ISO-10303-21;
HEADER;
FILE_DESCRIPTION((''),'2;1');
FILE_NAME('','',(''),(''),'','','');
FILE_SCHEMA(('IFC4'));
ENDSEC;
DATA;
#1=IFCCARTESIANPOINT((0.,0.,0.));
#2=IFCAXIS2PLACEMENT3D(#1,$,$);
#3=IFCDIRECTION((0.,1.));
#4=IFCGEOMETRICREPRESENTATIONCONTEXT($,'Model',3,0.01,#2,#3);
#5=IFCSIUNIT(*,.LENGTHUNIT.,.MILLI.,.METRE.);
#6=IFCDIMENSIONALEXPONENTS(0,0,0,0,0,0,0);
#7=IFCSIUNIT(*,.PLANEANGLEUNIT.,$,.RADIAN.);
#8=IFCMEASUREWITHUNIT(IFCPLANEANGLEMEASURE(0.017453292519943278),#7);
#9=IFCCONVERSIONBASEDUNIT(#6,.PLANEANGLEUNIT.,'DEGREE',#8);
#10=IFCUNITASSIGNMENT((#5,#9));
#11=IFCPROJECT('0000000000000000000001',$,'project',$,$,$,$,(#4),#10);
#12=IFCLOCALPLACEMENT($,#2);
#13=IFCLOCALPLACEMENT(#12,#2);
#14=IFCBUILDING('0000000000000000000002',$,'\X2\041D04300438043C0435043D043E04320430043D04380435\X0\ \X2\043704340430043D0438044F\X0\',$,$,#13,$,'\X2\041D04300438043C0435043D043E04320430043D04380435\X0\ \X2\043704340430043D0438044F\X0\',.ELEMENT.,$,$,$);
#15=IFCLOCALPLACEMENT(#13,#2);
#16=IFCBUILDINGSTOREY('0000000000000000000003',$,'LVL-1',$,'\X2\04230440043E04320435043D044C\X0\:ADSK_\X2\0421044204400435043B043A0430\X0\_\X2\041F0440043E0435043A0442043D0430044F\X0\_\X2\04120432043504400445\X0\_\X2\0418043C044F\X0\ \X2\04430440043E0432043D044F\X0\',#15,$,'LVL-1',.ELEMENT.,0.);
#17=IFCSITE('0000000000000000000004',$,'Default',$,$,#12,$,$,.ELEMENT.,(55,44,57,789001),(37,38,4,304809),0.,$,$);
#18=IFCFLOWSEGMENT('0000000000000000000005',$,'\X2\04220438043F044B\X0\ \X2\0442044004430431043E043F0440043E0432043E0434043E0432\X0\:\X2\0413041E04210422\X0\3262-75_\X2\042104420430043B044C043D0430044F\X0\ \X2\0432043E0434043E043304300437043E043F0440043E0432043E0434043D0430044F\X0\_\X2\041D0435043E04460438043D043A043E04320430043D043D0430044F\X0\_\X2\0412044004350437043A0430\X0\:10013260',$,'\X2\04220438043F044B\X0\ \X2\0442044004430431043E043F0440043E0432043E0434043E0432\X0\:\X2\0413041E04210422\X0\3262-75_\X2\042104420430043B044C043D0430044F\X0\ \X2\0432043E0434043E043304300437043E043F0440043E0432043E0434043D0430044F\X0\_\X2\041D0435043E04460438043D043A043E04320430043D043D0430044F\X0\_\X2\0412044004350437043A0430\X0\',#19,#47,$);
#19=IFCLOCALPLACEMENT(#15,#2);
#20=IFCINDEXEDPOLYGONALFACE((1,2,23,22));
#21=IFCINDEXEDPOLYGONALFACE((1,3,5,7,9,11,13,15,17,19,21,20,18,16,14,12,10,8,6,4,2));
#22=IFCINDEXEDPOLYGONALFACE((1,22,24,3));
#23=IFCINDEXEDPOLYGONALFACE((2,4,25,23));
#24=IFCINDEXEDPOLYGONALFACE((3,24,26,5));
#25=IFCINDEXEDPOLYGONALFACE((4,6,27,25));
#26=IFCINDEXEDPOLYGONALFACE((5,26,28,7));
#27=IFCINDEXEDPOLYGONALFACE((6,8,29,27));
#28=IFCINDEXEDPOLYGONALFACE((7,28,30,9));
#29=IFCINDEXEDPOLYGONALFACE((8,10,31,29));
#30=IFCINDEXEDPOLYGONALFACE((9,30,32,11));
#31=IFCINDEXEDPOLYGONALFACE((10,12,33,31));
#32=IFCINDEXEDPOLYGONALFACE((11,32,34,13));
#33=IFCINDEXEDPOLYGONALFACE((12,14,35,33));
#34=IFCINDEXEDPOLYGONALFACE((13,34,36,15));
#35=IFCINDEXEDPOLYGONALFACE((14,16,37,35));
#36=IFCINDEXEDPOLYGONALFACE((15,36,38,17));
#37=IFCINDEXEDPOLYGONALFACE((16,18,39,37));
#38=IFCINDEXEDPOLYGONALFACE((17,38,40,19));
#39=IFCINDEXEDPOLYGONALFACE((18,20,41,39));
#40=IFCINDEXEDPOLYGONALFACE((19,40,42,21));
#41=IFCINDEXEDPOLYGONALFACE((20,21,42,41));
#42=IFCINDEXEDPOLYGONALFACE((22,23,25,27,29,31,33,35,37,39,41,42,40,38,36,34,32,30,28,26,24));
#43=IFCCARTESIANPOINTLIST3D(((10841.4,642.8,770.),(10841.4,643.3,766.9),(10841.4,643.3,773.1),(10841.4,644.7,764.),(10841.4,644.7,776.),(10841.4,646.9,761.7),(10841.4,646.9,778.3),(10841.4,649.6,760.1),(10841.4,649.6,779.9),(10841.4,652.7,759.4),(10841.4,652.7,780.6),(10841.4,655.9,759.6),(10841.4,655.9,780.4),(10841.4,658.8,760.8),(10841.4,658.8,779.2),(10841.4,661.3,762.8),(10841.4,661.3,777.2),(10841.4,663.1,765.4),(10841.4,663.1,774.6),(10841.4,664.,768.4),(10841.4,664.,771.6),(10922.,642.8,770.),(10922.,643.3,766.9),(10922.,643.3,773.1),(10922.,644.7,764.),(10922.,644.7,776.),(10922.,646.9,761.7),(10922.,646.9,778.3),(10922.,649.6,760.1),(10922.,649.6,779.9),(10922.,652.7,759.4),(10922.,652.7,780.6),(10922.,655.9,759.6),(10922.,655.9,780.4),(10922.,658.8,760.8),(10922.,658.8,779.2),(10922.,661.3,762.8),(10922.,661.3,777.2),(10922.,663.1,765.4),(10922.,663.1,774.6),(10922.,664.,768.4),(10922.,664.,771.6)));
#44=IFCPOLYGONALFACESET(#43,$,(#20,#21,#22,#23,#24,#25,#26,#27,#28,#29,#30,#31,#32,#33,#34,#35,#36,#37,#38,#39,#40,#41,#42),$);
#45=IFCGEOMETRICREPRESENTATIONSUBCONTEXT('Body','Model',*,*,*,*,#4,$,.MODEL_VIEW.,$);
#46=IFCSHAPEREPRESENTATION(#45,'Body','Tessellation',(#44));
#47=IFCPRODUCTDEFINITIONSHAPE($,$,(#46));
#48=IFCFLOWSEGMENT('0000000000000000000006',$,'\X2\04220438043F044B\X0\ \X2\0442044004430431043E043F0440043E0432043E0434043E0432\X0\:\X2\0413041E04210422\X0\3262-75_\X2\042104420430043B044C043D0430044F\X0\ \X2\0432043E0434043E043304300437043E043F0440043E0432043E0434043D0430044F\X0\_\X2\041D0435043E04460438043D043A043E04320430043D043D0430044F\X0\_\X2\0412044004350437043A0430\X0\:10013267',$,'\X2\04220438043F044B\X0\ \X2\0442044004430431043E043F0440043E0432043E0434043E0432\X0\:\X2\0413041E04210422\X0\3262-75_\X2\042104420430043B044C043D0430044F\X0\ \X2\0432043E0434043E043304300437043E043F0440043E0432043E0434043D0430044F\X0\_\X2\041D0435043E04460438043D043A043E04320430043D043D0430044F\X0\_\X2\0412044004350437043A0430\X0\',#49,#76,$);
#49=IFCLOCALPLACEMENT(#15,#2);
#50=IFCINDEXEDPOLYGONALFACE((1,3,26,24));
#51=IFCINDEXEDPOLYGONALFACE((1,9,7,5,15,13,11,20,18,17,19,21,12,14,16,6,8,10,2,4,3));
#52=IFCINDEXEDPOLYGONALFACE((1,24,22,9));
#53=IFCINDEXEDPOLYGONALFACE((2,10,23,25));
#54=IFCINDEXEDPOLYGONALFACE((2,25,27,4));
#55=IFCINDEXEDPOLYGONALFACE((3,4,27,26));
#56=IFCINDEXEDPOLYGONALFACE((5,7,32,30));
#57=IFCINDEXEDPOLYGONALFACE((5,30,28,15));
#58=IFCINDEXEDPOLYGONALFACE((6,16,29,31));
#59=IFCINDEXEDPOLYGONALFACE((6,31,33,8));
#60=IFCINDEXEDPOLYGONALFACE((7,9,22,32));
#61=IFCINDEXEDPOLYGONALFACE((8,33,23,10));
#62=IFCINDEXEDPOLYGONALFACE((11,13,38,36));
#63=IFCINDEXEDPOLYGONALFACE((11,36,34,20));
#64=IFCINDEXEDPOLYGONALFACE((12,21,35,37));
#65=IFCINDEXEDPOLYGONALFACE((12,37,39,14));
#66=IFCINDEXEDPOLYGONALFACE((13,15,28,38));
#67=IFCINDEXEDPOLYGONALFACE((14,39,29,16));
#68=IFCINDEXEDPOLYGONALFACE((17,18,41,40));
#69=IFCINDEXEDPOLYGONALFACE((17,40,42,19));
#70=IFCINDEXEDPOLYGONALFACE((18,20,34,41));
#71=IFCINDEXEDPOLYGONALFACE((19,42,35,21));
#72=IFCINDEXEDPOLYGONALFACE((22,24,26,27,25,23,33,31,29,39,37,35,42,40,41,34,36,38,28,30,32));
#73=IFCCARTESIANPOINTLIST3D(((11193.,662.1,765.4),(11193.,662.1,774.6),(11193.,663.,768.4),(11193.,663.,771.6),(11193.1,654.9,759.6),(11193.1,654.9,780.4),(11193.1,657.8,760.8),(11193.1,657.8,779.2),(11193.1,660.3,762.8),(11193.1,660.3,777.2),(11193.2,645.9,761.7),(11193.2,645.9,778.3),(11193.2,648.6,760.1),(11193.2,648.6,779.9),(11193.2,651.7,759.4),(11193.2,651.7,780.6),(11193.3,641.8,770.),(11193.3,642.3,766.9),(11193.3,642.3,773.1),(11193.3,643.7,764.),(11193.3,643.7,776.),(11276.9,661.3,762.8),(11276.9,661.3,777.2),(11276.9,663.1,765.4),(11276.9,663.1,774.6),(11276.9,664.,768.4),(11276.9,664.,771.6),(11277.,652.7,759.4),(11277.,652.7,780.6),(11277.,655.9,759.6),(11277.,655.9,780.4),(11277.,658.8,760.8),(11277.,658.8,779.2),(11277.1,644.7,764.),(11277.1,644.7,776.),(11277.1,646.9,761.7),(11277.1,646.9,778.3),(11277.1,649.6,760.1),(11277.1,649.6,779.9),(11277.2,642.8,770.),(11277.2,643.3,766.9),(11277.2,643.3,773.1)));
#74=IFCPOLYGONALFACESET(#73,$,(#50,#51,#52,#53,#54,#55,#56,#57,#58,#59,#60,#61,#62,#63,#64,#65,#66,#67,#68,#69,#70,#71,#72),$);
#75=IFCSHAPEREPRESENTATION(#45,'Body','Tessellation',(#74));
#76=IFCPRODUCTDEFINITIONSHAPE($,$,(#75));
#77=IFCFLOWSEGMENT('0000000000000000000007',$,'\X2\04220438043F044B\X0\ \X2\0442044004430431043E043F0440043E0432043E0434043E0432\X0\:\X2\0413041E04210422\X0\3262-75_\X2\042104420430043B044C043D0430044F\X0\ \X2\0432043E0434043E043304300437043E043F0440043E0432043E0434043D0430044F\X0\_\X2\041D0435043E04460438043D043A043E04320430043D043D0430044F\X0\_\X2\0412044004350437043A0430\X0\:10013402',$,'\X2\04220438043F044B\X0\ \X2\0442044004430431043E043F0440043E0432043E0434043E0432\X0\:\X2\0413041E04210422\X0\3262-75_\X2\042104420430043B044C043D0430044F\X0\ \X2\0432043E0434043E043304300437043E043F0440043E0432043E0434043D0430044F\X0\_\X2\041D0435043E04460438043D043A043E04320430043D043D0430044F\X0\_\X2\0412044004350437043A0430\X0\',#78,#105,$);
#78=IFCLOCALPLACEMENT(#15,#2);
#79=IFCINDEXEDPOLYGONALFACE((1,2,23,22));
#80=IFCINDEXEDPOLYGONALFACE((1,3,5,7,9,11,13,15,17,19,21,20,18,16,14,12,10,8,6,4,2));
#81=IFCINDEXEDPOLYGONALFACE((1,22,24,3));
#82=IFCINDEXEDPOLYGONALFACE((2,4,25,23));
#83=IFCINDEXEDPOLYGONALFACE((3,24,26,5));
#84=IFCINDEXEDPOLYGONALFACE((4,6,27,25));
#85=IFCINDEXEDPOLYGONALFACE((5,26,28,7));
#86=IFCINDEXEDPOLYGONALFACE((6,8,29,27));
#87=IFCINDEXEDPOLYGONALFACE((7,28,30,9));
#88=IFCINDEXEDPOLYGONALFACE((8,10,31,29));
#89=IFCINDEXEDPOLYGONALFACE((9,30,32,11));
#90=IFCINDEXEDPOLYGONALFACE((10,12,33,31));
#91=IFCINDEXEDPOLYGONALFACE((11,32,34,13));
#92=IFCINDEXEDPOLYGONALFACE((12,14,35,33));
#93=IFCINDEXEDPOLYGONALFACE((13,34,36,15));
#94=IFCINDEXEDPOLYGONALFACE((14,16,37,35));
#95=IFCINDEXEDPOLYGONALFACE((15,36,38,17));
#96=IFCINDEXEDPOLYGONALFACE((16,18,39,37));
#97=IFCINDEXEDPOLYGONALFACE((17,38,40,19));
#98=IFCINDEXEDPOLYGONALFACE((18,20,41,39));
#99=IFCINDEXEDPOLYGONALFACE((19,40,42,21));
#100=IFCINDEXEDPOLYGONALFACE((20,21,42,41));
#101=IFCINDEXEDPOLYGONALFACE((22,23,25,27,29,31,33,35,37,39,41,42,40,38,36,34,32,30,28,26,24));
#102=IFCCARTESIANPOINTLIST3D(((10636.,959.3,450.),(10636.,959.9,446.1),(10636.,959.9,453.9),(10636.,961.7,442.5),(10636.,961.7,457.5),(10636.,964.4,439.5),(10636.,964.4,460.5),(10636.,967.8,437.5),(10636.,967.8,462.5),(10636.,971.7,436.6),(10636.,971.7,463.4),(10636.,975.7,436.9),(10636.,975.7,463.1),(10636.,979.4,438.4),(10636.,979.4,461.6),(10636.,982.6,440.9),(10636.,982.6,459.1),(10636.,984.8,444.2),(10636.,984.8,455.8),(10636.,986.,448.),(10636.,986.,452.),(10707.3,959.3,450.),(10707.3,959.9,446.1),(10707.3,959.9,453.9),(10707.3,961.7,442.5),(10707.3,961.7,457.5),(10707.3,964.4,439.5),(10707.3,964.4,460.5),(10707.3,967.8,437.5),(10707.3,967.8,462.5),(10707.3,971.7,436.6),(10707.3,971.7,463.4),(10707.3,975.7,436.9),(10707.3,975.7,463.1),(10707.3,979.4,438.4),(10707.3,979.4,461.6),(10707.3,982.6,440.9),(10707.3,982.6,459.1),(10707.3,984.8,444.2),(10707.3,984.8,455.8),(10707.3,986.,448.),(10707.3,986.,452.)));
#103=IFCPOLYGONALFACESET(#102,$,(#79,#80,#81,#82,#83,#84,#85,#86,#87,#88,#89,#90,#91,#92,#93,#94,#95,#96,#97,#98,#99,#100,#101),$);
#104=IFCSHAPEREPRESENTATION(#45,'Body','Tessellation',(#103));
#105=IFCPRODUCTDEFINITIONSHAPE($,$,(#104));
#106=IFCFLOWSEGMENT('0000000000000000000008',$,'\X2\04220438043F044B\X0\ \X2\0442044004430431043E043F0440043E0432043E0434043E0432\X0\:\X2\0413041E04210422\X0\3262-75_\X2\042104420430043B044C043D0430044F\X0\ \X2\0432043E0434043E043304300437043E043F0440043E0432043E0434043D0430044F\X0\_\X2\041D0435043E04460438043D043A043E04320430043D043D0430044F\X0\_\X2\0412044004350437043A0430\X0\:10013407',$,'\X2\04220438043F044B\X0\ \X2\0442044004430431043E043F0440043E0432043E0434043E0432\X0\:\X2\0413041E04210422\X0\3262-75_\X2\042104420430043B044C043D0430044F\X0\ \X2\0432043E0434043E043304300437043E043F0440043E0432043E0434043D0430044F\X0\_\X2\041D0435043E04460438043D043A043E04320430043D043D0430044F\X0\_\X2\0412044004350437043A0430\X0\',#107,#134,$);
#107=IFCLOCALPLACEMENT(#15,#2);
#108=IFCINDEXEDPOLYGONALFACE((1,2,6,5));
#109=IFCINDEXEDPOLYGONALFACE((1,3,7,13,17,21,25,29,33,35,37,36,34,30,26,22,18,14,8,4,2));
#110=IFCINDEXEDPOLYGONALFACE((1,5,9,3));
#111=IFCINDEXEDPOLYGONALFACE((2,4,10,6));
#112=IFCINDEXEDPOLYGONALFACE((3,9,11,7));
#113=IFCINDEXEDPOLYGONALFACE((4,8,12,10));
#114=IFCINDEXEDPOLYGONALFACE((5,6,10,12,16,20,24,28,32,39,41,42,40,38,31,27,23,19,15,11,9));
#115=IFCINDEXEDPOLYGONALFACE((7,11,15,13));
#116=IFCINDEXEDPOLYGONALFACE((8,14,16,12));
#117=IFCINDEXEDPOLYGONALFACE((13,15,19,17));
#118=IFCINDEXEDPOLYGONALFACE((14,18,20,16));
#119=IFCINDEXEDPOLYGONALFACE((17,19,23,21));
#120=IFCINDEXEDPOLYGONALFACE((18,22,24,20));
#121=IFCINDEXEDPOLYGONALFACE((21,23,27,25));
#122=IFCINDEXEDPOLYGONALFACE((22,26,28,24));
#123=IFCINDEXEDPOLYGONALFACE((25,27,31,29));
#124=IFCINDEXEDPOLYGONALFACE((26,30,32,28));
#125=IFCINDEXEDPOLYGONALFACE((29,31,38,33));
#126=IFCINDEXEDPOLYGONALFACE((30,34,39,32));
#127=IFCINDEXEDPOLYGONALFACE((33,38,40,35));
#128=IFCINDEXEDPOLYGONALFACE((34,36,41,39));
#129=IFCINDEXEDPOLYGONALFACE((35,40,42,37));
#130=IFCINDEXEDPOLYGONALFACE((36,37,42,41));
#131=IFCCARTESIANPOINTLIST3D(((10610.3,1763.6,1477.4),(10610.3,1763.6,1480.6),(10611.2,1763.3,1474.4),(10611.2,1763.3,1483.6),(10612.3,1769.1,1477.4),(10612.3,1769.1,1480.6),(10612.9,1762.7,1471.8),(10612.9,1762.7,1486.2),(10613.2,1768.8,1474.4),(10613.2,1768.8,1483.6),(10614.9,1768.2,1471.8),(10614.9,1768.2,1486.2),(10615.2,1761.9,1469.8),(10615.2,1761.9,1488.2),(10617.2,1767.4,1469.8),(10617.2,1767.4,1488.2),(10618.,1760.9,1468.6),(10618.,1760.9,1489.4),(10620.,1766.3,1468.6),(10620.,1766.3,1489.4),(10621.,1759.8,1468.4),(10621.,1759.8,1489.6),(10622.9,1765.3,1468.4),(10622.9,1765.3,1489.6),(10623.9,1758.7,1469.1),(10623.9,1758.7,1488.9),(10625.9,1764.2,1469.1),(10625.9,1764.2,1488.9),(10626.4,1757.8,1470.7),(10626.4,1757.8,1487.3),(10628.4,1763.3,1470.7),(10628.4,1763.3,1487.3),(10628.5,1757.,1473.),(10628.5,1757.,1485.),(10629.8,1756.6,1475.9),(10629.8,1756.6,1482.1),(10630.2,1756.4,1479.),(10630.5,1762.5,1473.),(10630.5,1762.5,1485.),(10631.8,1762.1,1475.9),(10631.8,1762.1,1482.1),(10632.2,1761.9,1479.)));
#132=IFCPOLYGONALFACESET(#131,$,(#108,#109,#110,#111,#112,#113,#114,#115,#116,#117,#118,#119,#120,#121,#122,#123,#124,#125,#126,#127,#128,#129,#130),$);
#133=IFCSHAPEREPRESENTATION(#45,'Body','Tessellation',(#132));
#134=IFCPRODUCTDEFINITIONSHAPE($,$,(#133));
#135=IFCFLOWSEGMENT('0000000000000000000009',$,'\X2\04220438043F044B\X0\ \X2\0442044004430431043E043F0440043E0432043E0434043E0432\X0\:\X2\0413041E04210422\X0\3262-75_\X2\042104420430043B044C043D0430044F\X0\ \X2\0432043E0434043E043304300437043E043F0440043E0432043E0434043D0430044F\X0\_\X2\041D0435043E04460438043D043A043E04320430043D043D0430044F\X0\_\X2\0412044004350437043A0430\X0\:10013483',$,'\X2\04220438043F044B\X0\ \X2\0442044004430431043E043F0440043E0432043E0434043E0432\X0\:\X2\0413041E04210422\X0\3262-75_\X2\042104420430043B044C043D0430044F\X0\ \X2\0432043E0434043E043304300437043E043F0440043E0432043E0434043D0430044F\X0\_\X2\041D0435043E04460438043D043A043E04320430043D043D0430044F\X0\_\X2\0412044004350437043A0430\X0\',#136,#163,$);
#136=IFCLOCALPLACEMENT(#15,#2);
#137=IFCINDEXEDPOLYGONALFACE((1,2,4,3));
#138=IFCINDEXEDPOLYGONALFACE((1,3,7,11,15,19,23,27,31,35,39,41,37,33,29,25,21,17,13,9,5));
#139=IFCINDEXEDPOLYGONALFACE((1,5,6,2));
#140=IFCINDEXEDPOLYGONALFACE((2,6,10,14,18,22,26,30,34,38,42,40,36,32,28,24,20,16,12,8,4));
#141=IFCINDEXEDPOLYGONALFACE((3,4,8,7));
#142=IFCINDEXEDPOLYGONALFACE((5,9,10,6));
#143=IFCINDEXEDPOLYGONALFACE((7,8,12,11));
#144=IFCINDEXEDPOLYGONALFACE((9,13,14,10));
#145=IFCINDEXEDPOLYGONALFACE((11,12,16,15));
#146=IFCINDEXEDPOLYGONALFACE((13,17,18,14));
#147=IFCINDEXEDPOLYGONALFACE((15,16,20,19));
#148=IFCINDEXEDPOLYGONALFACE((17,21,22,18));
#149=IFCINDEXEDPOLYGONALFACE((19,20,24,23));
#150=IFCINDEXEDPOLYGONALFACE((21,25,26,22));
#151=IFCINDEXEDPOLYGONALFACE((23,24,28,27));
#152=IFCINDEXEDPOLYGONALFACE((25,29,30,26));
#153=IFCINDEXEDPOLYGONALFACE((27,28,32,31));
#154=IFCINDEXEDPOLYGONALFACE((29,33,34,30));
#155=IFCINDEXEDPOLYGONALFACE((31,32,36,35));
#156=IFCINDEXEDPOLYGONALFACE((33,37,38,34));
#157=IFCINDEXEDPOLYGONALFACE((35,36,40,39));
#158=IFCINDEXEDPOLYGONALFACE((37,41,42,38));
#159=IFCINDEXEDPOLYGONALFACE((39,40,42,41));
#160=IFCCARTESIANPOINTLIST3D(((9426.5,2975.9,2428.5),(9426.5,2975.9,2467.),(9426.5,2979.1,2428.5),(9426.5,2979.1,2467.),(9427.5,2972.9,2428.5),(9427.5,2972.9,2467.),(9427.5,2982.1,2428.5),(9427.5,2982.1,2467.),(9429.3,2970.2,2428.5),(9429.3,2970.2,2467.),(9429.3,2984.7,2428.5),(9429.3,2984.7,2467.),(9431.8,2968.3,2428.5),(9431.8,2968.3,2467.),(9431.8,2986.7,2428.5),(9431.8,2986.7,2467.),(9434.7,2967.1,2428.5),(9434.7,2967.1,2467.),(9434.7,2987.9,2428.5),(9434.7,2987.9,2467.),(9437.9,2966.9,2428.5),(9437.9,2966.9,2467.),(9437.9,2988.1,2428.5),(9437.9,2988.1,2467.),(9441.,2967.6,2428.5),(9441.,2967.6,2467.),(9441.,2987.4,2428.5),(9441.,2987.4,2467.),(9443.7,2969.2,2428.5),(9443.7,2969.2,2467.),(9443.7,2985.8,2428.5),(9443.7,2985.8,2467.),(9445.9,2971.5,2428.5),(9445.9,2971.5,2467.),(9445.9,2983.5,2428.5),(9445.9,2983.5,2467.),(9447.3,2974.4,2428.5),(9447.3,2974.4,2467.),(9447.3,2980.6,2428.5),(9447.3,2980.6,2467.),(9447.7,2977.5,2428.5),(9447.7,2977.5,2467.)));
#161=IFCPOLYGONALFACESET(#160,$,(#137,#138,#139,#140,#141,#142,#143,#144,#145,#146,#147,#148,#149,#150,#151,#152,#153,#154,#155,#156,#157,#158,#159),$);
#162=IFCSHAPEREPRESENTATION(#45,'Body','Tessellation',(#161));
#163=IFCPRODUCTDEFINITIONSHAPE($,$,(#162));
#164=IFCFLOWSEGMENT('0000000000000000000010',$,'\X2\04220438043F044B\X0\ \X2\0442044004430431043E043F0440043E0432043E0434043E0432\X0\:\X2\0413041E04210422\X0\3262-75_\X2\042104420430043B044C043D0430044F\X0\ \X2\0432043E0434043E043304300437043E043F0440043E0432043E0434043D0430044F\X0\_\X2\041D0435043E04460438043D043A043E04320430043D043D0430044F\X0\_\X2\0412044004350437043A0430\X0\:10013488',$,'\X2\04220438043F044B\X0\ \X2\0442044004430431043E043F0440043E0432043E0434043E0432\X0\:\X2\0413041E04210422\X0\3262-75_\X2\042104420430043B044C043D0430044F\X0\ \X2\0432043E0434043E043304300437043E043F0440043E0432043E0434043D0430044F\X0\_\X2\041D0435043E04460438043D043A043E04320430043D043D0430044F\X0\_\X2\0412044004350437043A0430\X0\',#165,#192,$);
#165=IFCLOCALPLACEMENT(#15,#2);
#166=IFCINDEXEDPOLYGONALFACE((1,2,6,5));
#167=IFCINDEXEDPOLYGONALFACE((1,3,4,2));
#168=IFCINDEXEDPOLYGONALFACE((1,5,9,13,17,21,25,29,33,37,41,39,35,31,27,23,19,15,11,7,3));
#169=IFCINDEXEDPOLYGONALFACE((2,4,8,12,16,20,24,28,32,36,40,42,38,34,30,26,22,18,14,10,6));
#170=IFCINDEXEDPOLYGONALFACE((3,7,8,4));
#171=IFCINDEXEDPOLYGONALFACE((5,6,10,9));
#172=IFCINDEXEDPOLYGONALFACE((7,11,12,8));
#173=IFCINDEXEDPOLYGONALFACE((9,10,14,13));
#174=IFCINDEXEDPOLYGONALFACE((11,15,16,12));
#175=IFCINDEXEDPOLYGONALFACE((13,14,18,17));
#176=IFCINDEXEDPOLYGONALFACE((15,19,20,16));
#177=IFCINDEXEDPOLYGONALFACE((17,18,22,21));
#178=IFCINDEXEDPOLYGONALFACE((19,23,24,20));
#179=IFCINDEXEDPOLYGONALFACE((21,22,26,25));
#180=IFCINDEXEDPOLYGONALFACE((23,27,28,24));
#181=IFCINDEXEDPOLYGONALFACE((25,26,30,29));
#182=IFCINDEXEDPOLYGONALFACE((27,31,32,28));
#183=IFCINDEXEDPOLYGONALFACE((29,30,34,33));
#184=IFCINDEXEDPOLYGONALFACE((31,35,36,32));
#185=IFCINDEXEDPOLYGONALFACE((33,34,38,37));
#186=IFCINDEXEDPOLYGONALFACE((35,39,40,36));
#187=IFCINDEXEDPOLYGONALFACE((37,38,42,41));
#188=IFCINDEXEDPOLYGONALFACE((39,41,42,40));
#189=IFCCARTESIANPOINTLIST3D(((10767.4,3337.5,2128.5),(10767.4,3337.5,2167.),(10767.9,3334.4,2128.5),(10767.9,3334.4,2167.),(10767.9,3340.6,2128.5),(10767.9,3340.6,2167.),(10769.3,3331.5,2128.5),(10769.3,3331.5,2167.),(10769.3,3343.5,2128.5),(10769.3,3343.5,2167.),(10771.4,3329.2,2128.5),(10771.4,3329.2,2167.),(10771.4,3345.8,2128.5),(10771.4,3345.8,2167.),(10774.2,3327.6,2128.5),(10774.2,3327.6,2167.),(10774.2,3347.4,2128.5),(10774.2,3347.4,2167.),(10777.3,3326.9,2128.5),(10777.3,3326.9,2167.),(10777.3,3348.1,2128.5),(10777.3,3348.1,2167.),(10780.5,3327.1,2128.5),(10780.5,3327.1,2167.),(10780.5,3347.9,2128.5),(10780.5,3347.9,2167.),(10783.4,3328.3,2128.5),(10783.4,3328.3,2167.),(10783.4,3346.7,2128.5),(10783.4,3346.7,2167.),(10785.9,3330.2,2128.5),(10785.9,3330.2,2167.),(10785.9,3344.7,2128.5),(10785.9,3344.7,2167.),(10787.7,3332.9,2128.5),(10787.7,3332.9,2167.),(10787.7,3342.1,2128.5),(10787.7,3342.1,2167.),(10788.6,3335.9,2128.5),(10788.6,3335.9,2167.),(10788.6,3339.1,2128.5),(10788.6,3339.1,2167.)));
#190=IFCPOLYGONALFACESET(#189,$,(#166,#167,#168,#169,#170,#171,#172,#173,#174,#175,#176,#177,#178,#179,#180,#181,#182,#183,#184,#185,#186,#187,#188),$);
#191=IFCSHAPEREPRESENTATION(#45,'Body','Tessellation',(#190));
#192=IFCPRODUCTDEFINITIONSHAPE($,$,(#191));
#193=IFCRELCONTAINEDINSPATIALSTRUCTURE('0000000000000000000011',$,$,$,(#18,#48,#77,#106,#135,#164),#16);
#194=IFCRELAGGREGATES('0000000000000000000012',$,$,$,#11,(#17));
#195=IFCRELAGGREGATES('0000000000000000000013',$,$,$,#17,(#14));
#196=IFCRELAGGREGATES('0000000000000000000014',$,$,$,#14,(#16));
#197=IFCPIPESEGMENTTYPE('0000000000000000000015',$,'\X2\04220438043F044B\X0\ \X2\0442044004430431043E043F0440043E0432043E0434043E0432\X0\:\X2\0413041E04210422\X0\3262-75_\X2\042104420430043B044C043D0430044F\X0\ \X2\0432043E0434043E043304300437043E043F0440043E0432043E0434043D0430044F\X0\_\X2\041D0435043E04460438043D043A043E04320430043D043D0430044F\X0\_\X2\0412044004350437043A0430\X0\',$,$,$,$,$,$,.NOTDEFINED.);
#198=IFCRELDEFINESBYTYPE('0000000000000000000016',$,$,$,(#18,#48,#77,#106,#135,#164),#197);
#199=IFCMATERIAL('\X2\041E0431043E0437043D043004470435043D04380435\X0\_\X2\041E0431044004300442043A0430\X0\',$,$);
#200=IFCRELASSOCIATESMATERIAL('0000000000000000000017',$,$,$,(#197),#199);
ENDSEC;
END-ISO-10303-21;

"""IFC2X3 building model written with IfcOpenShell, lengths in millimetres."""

from ifc_helpers import new_model, entity, si_unit, converted_unit, direction, frame, frame_2d, origin, origin_2d_with_axis, place, context, subcontext, project, spatial, circle, extrude, material, type_object, element, save


model = new_model("IFC2X3")

# Units and contexts
model_context = context("Model", 3, precision=0.01, world=origin(), true_north=direction((0.0, 1.0)))
body_context = subcontext(model_context, "Body", "Model", "MODEL_VIEW")
ifc_project = project(units=[si_unit("LENGTHUNIT", "METRE", prefix="MILLI"), converted_unit("PLANEANGLEUNIT", "DEGREE", entity("IfcPlaneAngleMeasure", 0.017453292519943278), si_unit("PLANEANGLEUNIT", "RADIAN"), dimensions=[0, 0, 0, 0, 0, 0, 0])], contexts=[model_context])

# Site, building, storey
site_placement = place(None, origin())
site = spatial("IfcSite", under=ifc_project, at=site_placement, Name="Default", CompositionType="ELEMENT", RefLatitude=(55, 44, 57, 789001), RefLongitude=(37, 38, 4, 304809), RefElevation=0.0)
building_placement = place(site_placement, origin())
building = spatial("IfcBuilding", under=site, at=building_placement, Name="Наименование здания", LongName="Наименование здания", CompositionType="ELEMENT")
storey_placement = place(building_placement, origin())
storey = spatial("IfcBuildingStorey", under=building, at=storey_placement, Name="LVL-1", ObjectType="Уровень:ADSK_Стрелка_Проектная_Вверх_Имя уровня", LongName="LVL-1", CompositionType="ELEMENT", Elevation=0.0)

# Flow segments
ifc_material_1 = material(Name="Обозначение_Обратка")
pipe_segment_type_1 = type_object("IfcPipeSegmentType", Name="Типы трубопроводов:ГОСТ3262-75_Стальная водогазопроводная_Неоцинкованная_Врезка", PredefinedType="NOTDEFINED", material=ifc_material_1)
flow_segment_1_placement = place(storey_placement, origin())
element("IfcFlowSegment", 1, at=flow_segment_1_placement, inside=storey, type_object=pipe_segment_type_1, Name="Типы трубопроводов:ГОСТ3262-75_Стальная водогазопроводная_Неоцинкованная_Врезка:10013260", ObjectType="Типы трубопроводов:ГОСТ3262-75_Стальная водогазопроводная_Неоцинкованная_Врезка", context=body_context, shape_type="SweptSolid", body=[
    extrude(circle(Radius=10.7, at=origin_2d_with_axis()), frame((10841.4, 653.5, 770.0), z_axis=(1.0, 0.0, 0.0), x_axis=(0.0, -1.0, 0.0)), (0.0, 0.0, 1.0), 80.7),
])
flow_segment_2_placement = place(storey_placement, origin())
element("IfcFlowSegment", 2, at=flow_segment_2_placement, inside=storey, type_object=pipe_segment_type_1, Name="Типы трубопроводов:ГОСТ3262-75_Стальная водогазопроводная_Неоцинкованная_Врезка:10013267", ObjectType="Типы трубопроводов:ГОСТ3262-75_Стальная водогазопроводная_Неоцинкованная_Врезка", context=body_context, shape_type="SweptSolid", body=[
    extrude(circle(Radius=10.7, at=frame_2d((0.0, 0.0), x_axis=(1.0, 0.0))), frame((11193.2, 652.5, 770.0), z_axis=(0.999929, 0.011923, 0.0), x_axis=(0.011923, -0.999929, 0.0)), (0.0, 0.0, 1.0), 83.9),
])
flow_segment_3_placement = place(storey_placement, origin())
element("IfcFlowSegment", 3, at=flow_segment_3_placement, inside=storey, type_object=pipe_segment_type_1, Name="Типы трубопроводов:ГОСТ3262-75_Стальная водогазопроводная_Неоцинкованная_Врезка:10013402", ObjectType="Типы трубопроводов:ГОСТ3262-75_Стальная водогазопроводная_Неоцинкованная_Врезка", context=body_context, shape_type="SweptSolid", body=[
    extrude(circle(Radius=13.4, at=frame_2d((0.0, 0.0), x_axis=(1.0, 0.0))), frame((10636.0, 972.7, 450.0), z_axis=(1.0, 0.0, 0.0), x_axis=(0.0, -1.0, 0.0)), (0.0, 0.0, 1.0), 71.3),
])
flow_segment_4_placement = place(storey_placement, origin())
element("IfcFlowSegment", 4, at=flow_segment_4_placement, inside=storey, type_object=pipe_segment_type_1, Name="Типы трубопроводов:ГОСТ3262-75_Стальная водогазопроводная_Неоцинкованная_Врезка:10013407", ObjectType="Типы трубопроводов:ГОСТ3262-75_Стальная водогазопроводная_Неоцинкованная_Врезка", context=body_context, shape_type="SweptSolid", body=[
    extrude(circle(Radius=10.7, at=frame_2d((0.0, 0.0), x_axis=(1.0, 0.0))), frame((10620.2, 1760.0, 1479.0), z_axis=(0.34202, 0.939693, 0.0), x_axis=(0.939693, -0.34202, 0.0)), (0.0, 0.0, 1.0), 5.8),
])
flow_segment_5_placement = place(storey_placement, origin())
element("IfcFlowSegment", 5, at=flow_segment_5_placement, inside=storey, type_object=pipe_segment_type_1, Name="Типы трубопроводов:ГОСТ3262-75_Стальная водогазопроводная_Неоцинкованная_Врезка:10013483", ObjectType="Типы трубопроводов:ГОСТ3262-75_Стальная водогазопроводная_Неоцинкованная_Врезка", context=body_context, shape_type="SweptSolid", body=[
    extrude(circle(Radius=10.7, at=origin_2d_with_axis()), frame((9437.1, 2977.5, 2428.5)), (0.0, 0.0, 1.0), 38.5),
])
flow_segment_6_placement = place(storey_placement, origin())
element("IfcFlowSegment", 6, at=flow_segment_6_placement, inside=storey, type_object=pipe_segment_type_1, Name="Типы трубопроводов:ГОСТ3262-75_Стальная водогазопроводная_Неоцинкованная_Врезка:10013488", ObjectType="Типы трубопроводов:ГОСТ3262-75_Стальная водогазопроводная_Неоцинкованная_Врезка", context=body_context, shape_type="SweptSolid", body=[
    extrude(circle(Radius=10.7, at=origin_2d_with_axis()), frame((10778.1, 3337.5, 2128.5), z_axis=(0.0, 0.0, 1.0), x_axis=(-1.0, 0.0, 0.0)), (0.0, 0.0, 1.0), 38.5),
])

save(model, "model.ifc")
